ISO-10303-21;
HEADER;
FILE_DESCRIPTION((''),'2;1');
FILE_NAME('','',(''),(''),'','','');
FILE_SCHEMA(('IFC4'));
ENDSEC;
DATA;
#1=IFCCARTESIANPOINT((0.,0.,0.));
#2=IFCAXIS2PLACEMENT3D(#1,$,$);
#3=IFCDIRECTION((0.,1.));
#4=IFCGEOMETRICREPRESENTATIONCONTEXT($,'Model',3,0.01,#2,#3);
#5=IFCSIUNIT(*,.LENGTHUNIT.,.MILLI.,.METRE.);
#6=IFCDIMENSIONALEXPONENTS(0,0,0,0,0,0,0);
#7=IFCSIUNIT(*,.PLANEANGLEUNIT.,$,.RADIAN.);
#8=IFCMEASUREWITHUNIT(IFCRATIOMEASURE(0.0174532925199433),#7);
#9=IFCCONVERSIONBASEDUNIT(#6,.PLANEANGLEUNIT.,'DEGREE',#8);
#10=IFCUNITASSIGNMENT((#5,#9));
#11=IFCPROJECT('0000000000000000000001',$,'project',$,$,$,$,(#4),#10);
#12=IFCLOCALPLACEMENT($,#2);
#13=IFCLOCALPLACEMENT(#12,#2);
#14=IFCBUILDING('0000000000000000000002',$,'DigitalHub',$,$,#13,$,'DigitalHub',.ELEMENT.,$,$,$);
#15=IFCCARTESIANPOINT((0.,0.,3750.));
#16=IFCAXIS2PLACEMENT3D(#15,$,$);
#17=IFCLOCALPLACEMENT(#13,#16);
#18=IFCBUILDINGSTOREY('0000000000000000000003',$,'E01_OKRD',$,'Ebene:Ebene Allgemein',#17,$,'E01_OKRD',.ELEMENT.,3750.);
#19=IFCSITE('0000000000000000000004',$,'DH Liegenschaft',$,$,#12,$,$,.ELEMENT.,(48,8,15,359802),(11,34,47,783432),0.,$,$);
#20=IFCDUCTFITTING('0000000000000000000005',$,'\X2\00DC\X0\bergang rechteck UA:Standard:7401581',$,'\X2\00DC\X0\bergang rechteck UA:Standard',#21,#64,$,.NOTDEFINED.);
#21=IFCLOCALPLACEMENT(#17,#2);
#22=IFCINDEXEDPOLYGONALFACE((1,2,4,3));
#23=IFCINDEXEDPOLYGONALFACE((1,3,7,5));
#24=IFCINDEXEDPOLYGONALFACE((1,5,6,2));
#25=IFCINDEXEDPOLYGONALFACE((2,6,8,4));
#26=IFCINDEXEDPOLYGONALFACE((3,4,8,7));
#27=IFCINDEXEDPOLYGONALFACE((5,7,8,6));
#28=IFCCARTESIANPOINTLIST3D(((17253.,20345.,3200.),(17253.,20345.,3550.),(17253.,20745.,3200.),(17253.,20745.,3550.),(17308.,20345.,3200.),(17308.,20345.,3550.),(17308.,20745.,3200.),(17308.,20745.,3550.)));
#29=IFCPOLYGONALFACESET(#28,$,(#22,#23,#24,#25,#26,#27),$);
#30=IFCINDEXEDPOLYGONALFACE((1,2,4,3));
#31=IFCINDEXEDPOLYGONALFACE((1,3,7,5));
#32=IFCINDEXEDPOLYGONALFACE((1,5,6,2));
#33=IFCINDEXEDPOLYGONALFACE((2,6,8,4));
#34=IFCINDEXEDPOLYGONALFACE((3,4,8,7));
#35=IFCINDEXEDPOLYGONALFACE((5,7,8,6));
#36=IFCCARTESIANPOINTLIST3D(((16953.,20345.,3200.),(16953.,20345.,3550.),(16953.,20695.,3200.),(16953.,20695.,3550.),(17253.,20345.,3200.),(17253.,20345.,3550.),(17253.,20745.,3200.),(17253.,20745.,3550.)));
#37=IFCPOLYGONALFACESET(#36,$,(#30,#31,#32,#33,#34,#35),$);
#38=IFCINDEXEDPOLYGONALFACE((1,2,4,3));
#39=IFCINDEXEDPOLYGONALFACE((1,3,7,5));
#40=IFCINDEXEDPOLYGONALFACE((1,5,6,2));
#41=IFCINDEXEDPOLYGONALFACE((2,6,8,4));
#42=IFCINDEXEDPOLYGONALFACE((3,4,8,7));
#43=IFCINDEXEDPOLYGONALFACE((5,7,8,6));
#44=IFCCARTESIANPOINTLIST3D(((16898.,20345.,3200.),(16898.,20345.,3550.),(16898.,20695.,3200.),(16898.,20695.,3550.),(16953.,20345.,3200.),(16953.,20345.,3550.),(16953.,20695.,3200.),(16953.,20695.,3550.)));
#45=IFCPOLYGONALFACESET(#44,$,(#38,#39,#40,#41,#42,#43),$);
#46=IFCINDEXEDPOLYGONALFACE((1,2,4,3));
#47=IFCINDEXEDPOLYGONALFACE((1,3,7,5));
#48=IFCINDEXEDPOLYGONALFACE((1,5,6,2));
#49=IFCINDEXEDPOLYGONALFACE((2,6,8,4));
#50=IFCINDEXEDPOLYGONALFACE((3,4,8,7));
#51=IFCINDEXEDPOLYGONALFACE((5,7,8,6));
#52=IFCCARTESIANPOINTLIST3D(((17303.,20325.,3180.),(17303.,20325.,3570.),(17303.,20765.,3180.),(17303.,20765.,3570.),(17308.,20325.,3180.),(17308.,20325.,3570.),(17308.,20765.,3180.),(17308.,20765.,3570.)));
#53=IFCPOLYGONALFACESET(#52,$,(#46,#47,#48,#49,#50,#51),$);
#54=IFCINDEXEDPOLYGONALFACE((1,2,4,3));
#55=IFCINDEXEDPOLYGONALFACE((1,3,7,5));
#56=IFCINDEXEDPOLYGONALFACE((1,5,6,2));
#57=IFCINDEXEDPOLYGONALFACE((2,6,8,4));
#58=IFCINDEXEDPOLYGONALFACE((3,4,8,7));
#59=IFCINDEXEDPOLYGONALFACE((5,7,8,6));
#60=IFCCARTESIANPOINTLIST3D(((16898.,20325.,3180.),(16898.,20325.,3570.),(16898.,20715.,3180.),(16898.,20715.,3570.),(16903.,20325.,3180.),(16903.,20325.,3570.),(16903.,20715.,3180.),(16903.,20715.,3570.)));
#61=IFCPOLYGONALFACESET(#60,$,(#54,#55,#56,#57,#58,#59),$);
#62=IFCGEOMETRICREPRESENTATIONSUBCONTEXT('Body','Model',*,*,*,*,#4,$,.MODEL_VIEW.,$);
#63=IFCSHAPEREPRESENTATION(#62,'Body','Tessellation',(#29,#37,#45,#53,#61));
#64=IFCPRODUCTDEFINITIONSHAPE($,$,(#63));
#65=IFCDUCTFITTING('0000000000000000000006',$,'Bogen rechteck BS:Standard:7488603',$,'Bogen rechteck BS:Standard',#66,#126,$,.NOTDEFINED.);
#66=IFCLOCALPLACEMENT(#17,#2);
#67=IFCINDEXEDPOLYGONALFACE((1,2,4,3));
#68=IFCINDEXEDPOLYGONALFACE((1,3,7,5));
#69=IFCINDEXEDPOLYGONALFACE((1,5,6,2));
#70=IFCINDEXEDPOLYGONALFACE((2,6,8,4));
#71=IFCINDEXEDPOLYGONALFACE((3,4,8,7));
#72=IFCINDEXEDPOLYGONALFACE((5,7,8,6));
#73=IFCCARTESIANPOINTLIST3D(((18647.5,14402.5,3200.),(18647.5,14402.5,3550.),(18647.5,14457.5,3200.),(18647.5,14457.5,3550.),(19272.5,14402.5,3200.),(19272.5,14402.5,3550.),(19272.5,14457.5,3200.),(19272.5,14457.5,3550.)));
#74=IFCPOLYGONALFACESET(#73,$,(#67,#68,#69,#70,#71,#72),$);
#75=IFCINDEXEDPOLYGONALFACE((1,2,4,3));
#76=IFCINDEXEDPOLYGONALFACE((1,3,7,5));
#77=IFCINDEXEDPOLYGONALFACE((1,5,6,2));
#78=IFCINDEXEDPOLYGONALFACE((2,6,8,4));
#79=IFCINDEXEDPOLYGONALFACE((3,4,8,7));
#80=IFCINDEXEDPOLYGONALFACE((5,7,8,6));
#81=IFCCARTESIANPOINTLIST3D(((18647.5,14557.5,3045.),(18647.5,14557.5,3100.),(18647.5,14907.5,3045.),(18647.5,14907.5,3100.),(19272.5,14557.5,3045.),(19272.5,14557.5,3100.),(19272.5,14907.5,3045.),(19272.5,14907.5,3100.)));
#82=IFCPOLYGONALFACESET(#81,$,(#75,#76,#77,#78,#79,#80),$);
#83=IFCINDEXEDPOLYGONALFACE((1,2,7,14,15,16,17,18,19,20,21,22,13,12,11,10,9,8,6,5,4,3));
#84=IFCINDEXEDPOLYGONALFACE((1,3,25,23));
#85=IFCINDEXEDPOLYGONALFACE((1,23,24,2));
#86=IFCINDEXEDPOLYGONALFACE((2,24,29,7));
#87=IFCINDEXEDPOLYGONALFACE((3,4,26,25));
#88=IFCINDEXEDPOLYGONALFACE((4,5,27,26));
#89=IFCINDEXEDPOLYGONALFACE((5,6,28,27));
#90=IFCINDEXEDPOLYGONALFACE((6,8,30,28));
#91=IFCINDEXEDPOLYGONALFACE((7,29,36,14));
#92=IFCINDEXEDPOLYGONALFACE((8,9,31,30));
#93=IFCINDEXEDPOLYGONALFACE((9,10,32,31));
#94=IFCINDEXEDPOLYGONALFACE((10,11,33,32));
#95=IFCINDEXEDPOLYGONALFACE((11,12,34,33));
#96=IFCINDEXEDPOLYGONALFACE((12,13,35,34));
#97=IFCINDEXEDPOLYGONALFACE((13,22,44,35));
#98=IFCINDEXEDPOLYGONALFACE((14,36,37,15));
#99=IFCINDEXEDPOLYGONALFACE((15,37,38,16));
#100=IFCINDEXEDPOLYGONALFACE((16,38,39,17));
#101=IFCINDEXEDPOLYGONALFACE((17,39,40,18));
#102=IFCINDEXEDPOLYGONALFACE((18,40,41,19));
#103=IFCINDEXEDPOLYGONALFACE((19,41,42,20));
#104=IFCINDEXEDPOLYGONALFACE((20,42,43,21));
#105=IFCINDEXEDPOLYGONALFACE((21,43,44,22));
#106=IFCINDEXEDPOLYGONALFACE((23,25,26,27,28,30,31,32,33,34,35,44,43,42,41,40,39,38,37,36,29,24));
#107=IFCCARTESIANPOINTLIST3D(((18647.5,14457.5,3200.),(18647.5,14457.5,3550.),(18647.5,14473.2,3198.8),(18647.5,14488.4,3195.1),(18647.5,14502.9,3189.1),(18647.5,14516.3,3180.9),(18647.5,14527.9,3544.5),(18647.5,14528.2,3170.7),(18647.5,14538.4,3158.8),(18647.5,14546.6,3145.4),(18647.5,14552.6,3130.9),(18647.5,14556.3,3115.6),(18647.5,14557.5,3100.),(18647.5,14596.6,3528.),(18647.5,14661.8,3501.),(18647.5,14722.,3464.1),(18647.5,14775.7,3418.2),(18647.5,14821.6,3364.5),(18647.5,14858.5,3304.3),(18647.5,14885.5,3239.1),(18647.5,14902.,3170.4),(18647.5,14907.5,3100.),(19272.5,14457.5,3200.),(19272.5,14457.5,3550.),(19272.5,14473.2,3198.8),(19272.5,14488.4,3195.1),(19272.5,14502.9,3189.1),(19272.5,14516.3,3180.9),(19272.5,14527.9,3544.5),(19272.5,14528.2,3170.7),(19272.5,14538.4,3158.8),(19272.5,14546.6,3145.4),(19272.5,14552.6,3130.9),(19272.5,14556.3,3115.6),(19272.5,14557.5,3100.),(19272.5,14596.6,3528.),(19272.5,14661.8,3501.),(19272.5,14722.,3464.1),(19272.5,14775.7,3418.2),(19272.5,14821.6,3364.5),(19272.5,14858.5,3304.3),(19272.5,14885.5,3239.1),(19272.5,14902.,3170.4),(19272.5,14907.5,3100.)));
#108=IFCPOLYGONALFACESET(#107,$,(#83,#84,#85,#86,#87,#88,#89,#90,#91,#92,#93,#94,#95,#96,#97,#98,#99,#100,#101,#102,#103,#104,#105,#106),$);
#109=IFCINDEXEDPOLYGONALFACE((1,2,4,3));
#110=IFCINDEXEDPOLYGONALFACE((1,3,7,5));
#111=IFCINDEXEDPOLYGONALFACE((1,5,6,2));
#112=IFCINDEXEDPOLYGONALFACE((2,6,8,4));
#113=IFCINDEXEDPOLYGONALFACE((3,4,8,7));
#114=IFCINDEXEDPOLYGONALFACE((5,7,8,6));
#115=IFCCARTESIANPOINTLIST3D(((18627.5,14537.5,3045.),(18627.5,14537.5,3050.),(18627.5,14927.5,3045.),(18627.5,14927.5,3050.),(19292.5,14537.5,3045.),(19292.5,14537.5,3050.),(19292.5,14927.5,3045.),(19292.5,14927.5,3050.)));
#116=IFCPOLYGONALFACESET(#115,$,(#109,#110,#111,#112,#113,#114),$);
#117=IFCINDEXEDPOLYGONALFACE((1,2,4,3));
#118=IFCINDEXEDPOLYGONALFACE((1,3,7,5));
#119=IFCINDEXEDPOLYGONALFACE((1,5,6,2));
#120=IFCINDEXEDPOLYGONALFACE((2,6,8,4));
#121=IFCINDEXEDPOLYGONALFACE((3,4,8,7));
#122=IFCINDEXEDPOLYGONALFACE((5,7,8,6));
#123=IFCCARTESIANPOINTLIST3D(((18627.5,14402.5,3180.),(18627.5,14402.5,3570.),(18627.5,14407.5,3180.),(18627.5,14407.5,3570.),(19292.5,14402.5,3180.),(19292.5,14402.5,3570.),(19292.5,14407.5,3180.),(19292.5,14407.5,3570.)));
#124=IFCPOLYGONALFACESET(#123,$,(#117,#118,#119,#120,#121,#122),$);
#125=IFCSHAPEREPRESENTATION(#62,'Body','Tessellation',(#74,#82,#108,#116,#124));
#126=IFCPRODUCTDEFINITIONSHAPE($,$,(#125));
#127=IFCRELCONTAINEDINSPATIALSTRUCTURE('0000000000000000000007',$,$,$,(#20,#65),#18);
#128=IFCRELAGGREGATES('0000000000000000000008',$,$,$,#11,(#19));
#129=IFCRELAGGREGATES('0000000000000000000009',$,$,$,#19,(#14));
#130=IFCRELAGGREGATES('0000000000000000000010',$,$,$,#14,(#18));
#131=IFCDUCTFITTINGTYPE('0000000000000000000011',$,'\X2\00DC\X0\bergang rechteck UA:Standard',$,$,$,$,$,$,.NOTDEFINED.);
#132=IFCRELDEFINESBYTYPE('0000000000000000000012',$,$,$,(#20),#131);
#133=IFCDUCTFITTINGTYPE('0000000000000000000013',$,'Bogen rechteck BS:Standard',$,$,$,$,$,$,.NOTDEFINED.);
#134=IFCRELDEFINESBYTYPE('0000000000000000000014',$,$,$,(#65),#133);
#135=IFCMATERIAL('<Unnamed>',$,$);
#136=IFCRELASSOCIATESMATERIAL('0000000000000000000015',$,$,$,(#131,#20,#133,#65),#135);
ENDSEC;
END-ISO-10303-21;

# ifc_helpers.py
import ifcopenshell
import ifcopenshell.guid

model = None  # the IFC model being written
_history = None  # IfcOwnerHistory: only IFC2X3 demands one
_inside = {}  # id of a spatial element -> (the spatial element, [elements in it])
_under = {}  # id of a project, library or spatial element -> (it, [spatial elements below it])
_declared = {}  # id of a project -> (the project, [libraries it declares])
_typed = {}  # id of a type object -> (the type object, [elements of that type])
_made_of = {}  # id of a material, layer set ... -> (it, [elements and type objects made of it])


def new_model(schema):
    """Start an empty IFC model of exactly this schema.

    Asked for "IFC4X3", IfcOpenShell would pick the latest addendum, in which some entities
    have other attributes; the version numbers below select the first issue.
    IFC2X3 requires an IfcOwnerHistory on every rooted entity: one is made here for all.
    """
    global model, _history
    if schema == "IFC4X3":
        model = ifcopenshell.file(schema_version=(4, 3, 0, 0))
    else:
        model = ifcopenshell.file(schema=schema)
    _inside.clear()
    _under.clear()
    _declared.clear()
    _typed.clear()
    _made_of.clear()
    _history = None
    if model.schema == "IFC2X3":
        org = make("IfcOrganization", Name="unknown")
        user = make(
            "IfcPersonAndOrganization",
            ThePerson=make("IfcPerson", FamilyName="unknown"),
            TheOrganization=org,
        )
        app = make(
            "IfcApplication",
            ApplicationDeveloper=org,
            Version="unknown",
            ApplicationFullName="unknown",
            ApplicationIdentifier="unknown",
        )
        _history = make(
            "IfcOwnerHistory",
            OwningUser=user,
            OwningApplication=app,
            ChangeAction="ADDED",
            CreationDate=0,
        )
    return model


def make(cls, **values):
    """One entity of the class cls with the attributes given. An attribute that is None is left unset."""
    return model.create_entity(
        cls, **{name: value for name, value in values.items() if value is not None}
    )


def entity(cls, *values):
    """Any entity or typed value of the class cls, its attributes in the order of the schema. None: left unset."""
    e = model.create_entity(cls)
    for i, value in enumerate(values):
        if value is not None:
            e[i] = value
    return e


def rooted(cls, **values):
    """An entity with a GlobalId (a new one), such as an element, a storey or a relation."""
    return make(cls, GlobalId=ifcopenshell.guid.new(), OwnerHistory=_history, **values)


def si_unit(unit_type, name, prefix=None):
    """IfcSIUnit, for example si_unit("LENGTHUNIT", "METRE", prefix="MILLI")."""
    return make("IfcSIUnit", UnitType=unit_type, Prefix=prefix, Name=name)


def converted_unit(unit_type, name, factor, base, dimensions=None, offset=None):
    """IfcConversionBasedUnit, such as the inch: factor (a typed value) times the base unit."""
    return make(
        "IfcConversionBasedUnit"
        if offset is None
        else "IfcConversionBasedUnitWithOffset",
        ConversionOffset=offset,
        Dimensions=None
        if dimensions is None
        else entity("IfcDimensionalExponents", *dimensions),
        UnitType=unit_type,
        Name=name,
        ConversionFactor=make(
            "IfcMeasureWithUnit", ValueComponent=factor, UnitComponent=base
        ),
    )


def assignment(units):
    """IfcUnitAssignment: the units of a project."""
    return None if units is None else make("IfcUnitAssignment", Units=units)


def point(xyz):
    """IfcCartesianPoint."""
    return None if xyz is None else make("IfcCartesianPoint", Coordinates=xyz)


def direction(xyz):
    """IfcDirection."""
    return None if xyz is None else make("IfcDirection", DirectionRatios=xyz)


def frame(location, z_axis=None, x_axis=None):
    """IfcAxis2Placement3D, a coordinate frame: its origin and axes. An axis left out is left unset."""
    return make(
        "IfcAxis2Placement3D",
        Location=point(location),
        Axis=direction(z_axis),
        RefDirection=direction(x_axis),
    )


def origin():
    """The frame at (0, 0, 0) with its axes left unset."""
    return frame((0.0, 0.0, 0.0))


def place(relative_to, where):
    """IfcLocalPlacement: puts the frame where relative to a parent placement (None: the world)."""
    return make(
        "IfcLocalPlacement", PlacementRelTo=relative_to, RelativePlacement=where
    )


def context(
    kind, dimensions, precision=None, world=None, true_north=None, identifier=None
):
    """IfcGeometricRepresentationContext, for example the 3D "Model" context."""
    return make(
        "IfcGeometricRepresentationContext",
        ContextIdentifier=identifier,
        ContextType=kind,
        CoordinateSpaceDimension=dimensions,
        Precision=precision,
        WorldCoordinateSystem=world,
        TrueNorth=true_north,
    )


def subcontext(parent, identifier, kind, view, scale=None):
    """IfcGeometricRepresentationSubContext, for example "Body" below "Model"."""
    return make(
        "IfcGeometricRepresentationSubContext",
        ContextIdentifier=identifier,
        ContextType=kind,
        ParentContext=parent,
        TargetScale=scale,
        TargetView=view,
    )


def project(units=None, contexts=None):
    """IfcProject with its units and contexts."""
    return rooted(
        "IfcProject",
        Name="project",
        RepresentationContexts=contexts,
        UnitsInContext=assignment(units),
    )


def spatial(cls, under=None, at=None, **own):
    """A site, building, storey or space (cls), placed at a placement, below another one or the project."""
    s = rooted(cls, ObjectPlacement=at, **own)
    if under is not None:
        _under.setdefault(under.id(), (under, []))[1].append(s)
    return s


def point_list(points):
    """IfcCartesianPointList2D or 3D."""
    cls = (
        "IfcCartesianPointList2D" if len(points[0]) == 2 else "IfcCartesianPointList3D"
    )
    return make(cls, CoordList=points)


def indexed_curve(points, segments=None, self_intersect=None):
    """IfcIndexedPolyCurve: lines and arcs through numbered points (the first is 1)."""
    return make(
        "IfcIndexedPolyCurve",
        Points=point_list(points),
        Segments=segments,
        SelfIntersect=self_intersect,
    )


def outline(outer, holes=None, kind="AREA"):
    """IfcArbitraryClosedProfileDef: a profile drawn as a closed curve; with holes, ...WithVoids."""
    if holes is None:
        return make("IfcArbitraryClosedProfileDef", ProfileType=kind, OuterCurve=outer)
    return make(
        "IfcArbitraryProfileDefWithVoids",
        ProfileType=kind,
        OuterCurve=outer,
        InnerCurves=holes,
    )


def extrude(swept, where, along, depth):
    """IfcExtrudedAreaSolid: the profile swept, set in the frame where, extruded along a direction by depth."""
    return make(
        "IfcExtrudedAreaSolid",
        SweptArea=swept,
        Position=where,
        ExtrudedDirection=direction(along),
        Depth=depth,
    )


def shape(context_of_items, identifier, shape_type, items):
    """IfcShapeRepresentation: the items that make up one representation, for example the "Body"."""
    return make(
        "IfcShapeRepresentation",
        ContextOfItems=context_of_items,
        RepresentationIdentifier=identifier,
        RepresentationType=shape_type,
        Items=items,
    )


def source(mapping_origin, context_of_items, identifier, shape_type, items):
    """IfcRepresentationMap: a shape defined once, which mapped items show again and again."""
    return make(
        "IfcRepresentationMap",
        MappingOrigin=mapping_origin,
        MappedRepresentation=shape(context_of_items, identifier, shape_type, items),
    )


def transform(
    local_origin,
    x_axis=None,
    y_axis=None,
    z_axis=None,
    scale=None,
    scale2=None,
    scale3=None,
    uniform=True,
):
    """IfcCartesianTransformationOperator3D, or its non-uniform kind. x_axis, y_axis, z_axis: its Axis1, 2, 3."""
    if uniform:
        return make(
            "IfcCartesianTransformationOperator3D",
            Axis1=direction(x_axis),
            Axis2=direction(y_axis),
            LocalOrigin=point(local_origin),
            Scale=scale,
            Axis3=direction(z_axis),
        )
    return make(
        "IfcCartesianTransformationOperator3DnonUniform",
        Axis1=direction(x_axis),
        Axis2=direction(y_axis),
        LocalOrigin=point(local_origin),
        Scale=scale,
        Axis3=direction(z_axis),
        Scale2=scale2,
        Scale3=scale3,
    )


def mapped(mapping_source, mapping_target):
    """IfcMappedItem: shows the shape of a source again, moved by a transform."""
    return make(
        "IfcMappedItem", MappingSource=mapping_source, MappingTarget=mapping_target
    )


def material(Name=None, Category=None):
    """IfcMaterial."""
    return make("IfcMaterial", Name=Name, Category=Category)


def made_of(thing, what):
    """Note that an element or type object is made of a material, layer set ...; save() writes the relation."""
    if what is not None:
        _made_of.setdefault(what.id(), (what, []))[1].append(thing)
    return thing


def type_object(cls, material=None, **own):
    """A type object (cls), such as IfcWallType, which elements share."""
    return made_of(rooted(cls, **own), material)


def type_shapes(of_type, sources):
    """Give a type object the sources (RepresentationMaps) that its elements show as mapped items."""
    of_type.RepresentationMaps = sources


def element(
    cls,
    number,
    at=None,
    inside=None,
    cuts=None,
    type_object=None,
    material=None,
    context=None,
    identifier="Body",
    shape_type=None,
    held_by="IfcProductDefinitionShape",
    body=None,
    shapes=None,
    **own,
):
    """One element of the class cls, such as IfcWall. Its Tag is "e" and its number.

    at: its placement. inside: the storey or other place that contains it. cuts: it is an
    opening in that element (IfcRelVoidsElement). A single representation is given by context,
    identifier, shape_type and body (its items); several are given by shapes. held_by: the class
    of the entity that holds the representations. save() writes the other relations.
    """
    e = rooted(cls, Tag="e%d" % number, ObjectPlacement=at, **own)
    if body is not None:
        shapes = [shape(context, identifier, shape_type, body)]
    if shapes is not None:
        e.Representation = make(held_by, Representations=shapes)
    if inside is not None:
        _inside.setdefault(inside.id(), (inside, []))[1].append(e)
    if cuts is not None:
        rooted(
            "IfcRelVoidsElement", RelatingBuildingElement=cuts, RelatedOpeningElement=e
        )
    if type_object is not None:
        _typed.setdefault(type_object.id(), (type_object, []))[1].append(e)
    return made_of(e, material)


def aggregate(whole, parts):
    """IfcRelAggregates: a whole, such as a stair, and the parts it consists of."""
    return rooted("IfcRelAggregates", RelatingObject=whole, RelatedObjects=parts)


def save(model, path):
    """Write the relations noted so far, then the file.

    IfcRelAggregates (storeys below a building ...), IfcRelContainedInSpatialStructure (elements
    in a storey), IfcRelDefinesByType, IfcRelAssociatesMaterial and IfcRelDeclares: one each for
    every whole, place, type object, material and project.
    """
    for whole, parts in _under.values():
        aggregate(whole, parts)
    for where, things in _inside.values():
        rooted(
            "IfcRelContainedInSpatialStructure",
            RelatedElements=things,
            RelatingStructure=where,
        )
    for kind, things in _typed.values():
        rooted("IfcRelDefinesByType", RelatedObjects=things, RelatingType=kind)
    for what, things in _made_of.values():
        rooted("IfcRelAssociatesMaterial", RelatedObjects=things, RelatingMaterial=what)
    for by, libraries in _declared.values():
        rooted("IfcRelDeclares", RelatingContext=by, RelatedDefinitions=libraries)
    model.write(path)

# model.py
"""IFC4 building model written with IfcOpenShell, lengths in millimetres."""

from ifc_helpers import new_model, entity, si_unit, converted_unit, direction, frame, origin, place, context, subcontext, project, spatial, indexed_curve, outline, extrude, source, transform, mapped, material, type_object, type_shapes, element, save


model = new_model("IFC4")

# Units and contexts
model_context = context("Model", 3, precision=0.01, world=origin(), true_north=direction((0.0, 1.0)))
body_context = subcontext(model_context, "Body", "Model", "MODEL_VIEW")
ifc_project = project(units=[si_unit("LENGTHUNIT", "METRE", prefix="MILLI"), converted_unit("PLANEANGLEUNIT", "DEGREE", entity("IfcRatioMeasure", 0.0174532925199433), si_unit("PLANEANGLEUNIT", "RADIAN"), dimensions=[0, 0, 0, 0, 0, 0, 0])], contexts=[model_context])

# Site, building, storey
site_placement = place(None, origin())
site = spatial("IfcSite", under=ifc_project, at=site_placement, Name="DH Liegenschaft", CompositionType="ELEMENT", RefLatitude=(48, 8, 15, 359802), RefLongitude=(11, 34, 47, 783432), RefElevation=0.0)
building_placement = place(site_placement, origin())
building = spatial("IfcBuilding", under=site, at=building_placement, Name="DigitalHub", LongName="DigitalHub", CompositionType="ELEMENT")
storey_placement = place(building_placement, frame((0.0, 0.0, 3750.0)))
storey = spatial("IfcBuildingStorey", under=building, at=storey_placement, Name="E01_OKRD", ObjectType="Ebene:Ebene Allgemein", LongName="E01_OKRD", CompositionType="ELEMENT", Elevation=3750.0)

# Shared definitions
ifc_material_1 = material(Name="<Unnamed>")

# Duct fittings
duct_fitting_type_1 = type_object("IfcDuctFittingType", Name="Übergang rechteck UA:Standard", PredefinedType="NOTDEFINED", material=ifc_material_1)
shared_shape_1 = source(origin(), body_context, "Body", "SweptSolid", [
    extrude(outline(indexed_curve([(-27.5, -200.0), (27.5, -200.0), (27.5, 200.0), (-27.5, 200.0), (-27.5, -200.0)], self_intersect=False)), frame((382.5, 25.0, -175.0)), (0.0, 0.0, 1.0), 350.0),
    extrude(outline(indexed_curve([(-150.0, -187.5), (150.0, -187.5), (150.0, 212.5), (-150.0, 162.5), (-150.0, -187.5)], self_intersect=False)), frame((205.0, 12.5, -175.0)), (0.0, 0.0, 1.0), 350.0),
    extrude(outline(indexed_curve([(-27.5, -175.0), (27.5, -175.0), (27.5, 175.0), (-27.5, 175.0), (-27.5, -175.0)], self_intersect=False)), frame((27.5, 0.0, -175.0)), (0.0, 0.0, 1.0), 350.0),
    extrude(outline(indexed_curve([(-2.5, -220.0), (2.5, -220.0), (2.5, 220.0), (-2.5, 220.0), (-2.5, -220.0)], self_intersect=False)), frame((407.5, 25.0, -195.0)), (0.0, 0.0, 1.0), 390.0),
    extrude(outline(indexed_curve([(-2.5, -195.0), (2.5, -195.0), (2.5, 195.0), (-2.5, 195.0), (-2.5, -195.0)], self_intersect=False)), frame((2.5, 0.0, -195.0)), (0.0, 0.0, 1.0), 390.0),
])
type_shapes(duct_fitting_type_1, [shared_shape_1])
duct_fitting_1_placement = place(storey_placement, frame((16898.0, 20520.0, 3375.0)))
element("IfcDuctFitting", 1, at=duct_fitting_1_placement, inside=storey, type_object=duct_fitting_type_1, material=ifc_material_1, Name="Übergang rechteck UA:Standard:7401581", ObjectType="Übergang rechteck UA:Standard", PredefinedType="NOTDEFINED", context=body_context, shape_type="MappedRepresentation", body=[
    mapped(shared_shape_1, transform((0.0, 0.0, 0.0), scale=1.0)),
])
duct_fitting_type_2 = type_object("IfcDuctFittingType", Name="Bogen rechteck BS:Standard", PredefinedType="NOTDEFINED", material=ifc_material_1)
shared_shape_2 = source(origin(), body_context, "Body", "SweptSolid", [
    extrude(outline(indexed_curve([(-27.5, -175.0), (27.5, -175.0), (27.5, 175.0), (-27.5, 175.0), (-27.5, -175.0)], self_intersect=False)), frame((0.0, 302.5, -312.5), z_axis=(0.0, 0.0, 1.0), x_axis=(0.0, 1.0, 0.0)), (0.0, 0.0, 1.0), 625.0),
    extrude(outline(indexed_curve([(-175.0, -27.5), (175.0, -27.5), (175.0, 27.5), (-175.0, 27.5), (-175.0, -27.5)], self_intersect=False)), frame((-302.5, 0.0, -312.5), z_axis=(0.0, 0.0, 1.0), x_axis=(0.0, -1.0, 0.0)), (0.0, 0.0, 1.0), 625.0),
    extrude(outline(indexed_curve([(-312.5, -137.5), (37.5, -137.5), (38.7, -121.9), (42.4, -106.6), (48.4, -92.1), (56.6, -78.7), (66.8, -66.8), (78.7, -56.6), (92.1, -48.4), (106.6, -42.4), (121.9, -38.7), (137.5, -37.5), (137.5, 312.5), (67.1, 307.0), (-1.6, 290.5), (-66.8, 263.5), (-127.0, 226.6), (-180.7, 180.7), (-226.6, 127.0), (-263.5, 66.8), (-290.5, 1.6), (-307.0, -67.1), (-312.5, -137.5)], self_intersect=False)), frame((-137.5, 137.5, -312.5), z_axis=(0.0, 0.0, 1.0), x_axis=(-1.0, 0.0, 0.0)), (0.0, 0.0, 1.0), 625.0),
    extrude(outline(indexed_curve([(-2.5, -195.0), (2.5, -195.0), (2.5, 195.0), (-2.5, 195.0), (-2.5, -195.0)], self_intersect=False)), frame((-327.5, 0.0, -332.5)), (0.0, 0.0, 1.0), 665.0),
    extrude(outline(indexed_curve([(-2.5, -195.0), (2.5, -195.0), (2.5, 195.0), (-2.5, 195.0), (-2.5, -195.0)], self_intersect=False)), frame((0.0, 327.5, -332.5), z_axis=(0.0, 0.0, 1.0), x_axis=(0.0, 1.0, 0.0)), (0.0, 0.0, 1.0), 665.0),
])
type_shapes(duct_fitting_type_2, [shared_shape_2])
duct_fitting_2_placement = place(storey_placement, frame((18960.0, 14732.5, 3375.0), z_axis=(1.0, 0.0, 0.0), x_axis=(0.0, 0.0, 1.0)))
element("IfcDuctFitting", 2, at=duct_fitting_2_placement, inside=storey, type_object=duct_fitting_type_2, material=ifc_material_1, Name="Bogen rechteck BS:Standard:7488603", ObjectType="Bogen rechteck BS:Standard", PredefinedType="NOTDEFINED", context=body_context, shape_type="MappedRepresentation", body=[
    mapped(shared_shape_2, transform((0.0, 0.0, 0.0), scale=1.0)),
])

save(model, "model.ifc")
